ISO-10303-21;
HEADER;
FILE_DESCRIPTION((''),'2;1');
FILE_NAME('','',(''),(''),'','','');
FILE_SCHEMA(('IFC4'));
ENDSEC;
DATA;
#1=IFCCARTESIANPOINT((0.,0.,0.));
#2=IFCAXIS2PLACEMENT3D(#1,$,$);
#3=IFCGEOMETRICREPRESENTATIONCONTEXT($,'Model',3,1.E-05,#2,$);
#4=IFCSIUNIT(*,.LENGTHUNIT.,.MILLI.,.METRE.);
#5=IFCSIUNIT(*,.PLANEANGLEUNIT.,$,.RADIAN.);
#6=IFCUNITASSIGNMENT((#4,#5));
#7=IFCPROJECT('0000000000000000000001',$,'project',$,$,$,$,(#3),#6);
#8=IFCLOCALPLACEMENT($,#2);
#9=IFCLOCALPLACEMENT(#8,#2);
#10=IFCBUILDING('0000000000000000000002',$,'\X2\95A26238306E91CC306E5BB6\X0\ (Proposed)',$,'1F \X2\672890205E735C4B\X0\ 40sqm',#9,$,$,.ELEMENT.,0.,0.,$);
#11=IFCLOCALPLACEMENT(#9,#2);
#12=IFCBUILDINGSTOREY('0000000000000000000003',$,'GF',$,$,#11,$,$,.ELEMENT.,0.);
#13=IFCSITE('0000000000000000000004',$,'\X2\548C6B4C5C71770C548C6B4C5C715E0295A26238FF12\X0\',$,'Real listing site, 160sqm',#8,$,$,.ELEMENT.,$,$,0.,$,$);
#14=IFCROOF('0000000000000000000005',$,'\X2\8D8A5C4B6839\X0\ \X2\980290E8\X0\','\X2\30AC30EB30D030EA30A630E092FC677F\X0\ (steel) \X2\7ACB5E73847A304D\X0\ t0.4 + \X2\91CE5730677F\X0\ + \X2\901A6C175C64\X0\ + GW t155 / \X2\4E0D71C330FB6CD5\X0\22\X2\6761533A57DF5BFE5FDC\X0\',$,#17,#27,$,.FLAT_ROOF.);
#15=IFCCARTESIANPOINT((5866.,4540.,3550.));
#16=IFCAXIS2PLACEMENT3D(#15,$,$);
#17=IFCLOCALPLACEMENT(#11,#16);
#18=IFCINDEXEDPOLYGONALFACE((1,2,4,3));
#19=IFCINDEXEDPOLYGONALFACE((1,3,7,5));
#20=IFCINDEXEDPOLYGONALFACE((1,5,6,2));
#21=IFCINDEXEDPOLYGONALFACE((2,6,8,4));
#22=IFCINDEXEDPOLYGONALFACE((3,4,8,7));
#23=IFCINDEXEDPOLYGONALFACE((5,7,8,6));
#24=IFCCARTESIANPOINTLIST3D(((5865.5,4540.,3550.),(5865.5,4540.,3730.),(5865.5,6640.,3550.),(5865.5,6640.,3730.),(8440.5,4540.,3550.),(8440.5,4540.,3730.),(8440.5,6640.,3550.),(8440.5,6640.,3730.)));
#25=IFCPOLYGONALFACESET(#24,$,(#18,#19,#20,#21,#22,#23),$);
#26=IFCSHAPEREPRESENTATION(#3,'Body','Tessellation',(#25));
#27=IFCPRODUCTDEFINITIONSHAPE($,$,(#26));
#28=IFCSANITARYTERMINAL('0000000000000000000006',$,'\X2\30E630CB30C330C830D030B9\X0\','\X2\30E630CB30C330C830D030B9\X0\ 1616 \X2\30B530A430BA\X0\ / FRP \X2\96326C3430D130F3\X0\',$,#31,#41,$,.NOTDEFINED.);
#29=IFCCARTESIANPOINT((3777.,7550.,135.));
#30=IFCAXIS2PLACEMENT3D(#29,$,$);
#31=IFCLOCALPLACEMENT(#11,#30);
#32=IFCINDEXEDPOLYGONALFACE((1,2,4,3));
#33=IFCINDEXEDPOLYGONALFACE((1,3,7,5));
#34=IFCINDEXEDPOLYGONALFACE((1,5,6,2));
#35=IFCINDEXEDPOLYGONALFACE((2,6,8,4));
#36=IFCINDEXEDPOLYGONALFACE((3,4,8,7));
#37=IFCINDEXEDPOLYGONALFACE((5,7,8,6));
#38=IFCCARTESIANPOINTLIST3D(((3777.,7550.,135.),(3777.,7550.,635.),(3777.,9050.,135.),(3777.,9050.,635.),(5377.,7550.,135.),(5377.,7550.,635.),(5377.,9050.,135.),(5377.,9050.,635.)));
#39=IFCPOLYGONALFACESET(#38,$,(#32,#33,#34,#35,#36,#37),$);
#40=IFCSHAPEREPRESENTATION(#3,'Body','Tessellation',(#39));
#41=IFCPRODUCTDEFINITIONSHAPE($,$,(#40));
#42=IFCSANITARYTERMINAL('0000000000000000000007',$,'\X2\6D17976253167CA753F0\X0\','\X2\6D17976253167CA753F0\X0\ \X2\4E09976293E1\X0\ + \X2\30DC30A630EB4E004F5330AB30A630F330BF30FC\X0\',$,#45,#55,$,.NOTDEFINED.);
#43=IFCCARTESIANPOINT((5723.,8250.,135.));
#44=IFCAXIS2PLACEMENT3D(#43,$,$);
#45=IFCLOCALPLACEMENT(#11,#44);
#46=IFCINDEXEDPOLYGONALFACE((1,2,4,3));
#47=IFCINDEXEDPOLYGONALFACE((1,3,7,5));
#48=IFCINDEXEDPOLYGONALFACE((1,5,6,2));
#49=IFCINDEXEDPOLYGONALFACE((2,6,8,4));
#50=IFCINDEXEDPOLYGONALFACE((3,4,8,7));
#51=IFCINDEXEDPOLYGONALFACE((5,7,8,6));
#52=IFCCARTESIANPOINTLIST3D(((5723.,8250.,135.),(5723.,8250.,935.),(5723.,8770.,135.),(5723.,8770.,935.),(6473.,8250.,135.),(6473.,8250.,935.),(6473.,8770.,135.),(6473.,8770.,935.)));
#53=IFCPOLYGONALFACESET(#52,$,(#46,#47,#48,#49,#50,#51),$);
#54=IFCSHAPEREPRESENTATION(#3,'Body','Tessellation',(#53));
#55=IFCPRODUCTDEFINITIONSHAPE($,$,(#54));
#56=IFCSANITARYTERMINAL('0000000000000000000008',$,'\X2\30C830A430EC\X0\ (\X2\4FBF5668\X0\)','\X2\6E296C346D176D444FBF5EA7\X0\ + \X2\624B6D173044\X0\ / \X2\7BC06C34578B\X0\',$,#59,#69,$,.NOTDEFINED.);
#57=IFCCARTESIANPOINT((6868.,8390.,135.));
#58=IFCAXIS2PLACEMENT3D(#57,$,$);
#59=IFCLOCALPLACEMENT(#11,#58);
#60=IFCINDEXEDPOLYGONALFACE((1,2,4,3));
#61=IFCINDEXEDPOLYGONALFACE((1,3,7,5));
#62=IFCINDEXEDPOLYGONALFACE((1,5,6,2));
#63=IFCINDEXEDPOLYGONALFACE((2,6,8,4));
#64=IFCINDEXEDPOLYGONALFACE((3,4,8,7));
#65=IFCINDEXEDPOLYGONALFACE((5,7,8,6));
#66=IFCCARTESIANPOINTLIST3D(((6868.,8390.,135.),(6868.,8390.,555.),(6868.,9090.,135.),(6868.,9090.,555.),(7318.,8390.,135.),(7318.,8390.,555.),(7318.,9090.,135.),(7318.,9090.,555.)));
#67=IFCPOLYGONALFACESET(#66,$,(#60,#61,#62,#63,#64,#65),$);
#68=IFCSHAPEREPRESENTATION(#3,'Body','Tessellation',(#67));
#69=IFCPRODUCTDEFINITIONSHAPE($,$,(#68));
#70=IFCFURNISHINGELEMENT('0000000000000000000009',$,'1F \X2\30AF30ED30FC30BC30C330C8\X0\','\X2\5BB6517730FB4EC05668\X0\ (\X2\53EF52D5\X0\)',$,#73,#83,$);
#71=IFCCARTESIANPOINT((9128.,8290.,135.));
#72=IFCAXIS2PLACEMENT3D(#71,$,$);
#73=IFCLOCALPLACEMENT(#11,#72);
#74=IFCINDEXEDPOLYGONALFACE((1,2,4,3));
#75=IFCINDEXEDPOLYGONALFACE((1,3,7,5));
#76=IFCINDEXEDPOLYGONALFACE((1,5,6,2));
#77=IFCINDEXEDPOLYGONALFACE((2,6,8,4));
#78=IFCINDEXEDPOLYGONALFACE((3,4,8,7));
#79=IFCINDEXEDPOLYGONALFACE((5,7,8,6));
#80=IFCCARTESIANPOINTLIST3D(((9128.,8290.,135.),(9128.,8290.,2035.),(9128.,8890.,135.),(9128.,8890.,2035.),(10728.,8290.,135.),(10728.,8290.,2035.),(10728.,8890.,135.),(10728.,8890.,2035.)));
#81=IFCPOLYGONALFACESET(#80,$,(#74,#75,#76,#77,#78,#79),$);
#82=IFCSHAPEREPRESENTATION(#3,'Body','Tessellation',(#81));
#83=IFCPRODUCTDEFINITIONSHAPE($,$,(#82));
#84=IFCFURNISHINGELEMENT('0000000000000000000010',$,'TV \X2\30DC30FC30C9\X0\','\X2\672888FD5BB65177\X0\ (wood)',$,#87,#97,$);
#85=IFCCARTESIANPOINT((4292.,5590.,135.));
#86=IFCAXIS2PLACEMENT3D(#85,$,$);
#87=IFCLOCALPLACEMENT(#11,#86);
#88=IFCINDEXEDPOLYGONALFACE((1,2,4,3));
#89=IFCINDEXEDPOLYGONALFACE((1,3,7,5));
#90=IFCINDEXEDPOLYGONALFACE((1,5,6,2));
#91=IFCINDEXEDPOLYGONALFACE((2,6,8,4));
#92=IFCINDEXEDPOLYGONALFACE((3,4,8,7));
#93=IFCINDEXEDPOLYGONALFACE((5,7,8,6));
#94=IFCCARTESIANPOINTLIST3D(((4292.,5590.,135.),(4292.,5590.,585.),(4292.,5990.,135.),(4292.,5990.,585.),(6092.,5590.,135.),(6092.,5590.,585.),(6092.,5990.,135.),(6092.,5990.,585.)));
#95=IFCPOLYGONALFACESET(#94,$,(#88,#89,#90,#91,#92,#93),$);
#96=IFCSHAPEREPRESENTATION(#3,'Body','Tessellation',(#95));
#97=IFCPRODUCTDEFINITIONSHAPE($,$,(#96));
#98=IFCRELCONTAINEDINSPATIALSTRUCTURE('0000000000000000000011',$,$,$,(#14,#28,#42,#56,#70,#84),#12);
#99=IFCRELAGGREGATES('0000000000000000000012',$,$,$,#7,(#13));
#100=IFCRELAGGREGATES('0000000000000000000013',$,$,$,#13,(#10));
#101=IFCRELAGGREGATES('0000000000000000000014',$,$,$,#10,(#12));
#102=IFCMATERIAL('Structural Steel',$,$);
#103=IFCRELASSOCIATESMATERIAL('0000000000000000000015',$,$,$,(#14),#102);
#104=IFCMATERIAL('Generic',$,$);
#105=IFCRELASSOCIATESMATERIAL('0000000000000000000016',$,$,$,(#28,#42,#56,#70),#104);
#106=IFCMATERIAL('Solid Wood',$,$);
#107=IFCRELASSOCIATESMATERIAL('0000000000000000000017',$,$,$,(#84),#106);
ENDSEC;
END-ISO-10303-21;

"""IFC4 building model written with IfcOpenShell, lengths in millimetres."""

from ifc_helpers import new_model, si_unit, frame, frame_2d, origin, place, context, project, spatial, rectangle, extrude, material, element, save


model = new_model("IFC4")

# Units and contexts
model_context = context("Model", 3, precision=1e-05, world=origin())
ifc_project = project(units=[si_unit("LENGTHUNIT", "METRE", prefix="MILLI"), si_unit("PLANEANGLEUNIT", "RADIAN")], contexts=[model_context])

# Site, building, storey
site_placement = place(None, origin())
site = spatial("IfcSite", under=ifc_project, at=site_placement, Name="和歌山県和歌山市関戸２", ObjectType="Real listing site, 160sqm", CompositionType="ELEMENT", RefElevation=0.0)
building_placement = place(site_placement, origin())
building = spatial("IfcBuilding", under=site, at=building_placement, Name="関戸の里の家 (Proposed)", ObjectType="1F 木造平屋 40sqm", CompositionType="ELEMENT", ElevationOfRefHeight=0.0, ElevationOfTerrain=0.0)
storey_placement = place(building_placement, origin())
storey = spatial("IfcBuildingStorey", under=building, at=storey_placement, Name="GF", CompositionType="ELEMENT", Elevation=0.0)

# Shared definitions
ifc_material_1 = material(Name="Solid Wood")

# Roof
ifc_material_2 = material(Name="Structural Steel")
roof_placement = place(storey_placement, frame((5866.0, 4540.0, 3550.0)))
element("IfcRoof", 1, at=roof_placement, inside=storey, material=ifc_material_2, Name="越屋根 頂部", Description="ガルバリウム鋼板 (steel) 立平葺き t0.4 + 野地板 + 通気層 + GW t155 / 不燃・法22条区域対応", PredefinedType="FLAT_ROOF", context=model_context, shape_type="SweptSolid", body=[
    extrude(rectangle(XDim=2575.0, YDim=2100.0, at=frame_2d((1287.0, 1050.0))), frame((5866.0, 4540.0, 3550.0)), (0.0, 0.0, 1.0), 180.0),
])

# Sanitary terminals
ifc_material_3 = material(Name="Generic")
sanitary_terminal_1_placement = place(storey_placement, frame((3777.0, 7550.0, 135.0)))
element("IfcSanitaryTerminal", 2, at=sanitary_terminal_1_placement, inside=storey, material=ifc_material_3, Name="ユニットバス", Description="ユニットバス 1616 サイズ / FRP 防水パン", PredefinedType="NOTDEFINED", context=model_context, shape_type="SweptSolid", body=[
    extrude(rectangle(XDim=1600.0, YDim=1500.0, at=frame_2d((800.0, 750.0))), frame((3777.0, 7550.0, 135.0)), (0.0, 0.0, 1.0), 500.0),
])
sanitary_terminal_2_placement = place(storey_placement, frame((5723.0, 8250.0, 135.0)))
element("IfcSanitaryTerminal", 3, at=sanitary_terminal_2_placement, inside=storey, material=ifc_material_3, Name="洗面化粧台", Description="洗面化粧台 三面鏡 + ボウル一体カウンター", PredefinedType="NOTDEFINED", context=model_context, shape_type="SweptSolid", body=[
    extrude(rectangle(XDim=750.0, YDim=520.0, at=frame_2d((375.0, 260.0))), frame((5723.0, 8250.0, 135.0)), (0.0, 0.0, 1.0), 800.0),
])
sanitary_terminal_3_placement = place(storey_placement, frame((6868.0, 8390.0, 135.0)))
element("IfcSanitaryTerminal", 4, at=sanitary_terminal_3_placement, inside=storey, material=ifc_material_3, Name="トイレ (便器)", Description="温水洗浄便座 + 手洗い / 節水型", PredefinedType="NOTDEFINED", context=model_context, shape_type="SweptSolid", body=[
    extrude(rectangle(XDim=450.0, YDim=700.0, at=frame_2d((225.0, 350.0))), frame((6868.0, 8390.0, 135.0)), (0.0, 0.0, 1.0), 420.0),
])

# Furnishing elements
furnishing_1_placement = place(storey_placement, frame((9128.0, 8290.0, 135.0)))
element("IfcFurnishingElement", 5, at=furnishing_1_placement, inside=storey, material=ifc_material_3, Name="1F クローゼット", Description="家具・什器 (可動)", context=model_context, shape_type="SweptSolid", body=[
    extrude(rectangle(XDim=1600.0, YDim=600.0, at=frame_2d((800.0, 300.0))), frame((9128.0, 8290.0, 135.0)), (0.0, 0.0, 1.0), 1900.0),
])
furnishing_2_placement = place(storey_placement, frame((4292.0, 5590.0, 135.0)))
element("IfcFurnishingElement", 6, at=furnishing_2_placement, inside=storey, material=ifc_material_1, Name="TV ボード", Description="木製家具 (wood)", context=model_context, shape_type="SweptSolid", body=[
    extrude(rectangle(XDim=1800.0, YDim=400.0, at=frame_2d((900.0, 200.0))), frame((4292.0, 5590.0, 135.0)), (0.0, 0.0, 1.0), 450.0),
])

save(model, "model.ifc")
